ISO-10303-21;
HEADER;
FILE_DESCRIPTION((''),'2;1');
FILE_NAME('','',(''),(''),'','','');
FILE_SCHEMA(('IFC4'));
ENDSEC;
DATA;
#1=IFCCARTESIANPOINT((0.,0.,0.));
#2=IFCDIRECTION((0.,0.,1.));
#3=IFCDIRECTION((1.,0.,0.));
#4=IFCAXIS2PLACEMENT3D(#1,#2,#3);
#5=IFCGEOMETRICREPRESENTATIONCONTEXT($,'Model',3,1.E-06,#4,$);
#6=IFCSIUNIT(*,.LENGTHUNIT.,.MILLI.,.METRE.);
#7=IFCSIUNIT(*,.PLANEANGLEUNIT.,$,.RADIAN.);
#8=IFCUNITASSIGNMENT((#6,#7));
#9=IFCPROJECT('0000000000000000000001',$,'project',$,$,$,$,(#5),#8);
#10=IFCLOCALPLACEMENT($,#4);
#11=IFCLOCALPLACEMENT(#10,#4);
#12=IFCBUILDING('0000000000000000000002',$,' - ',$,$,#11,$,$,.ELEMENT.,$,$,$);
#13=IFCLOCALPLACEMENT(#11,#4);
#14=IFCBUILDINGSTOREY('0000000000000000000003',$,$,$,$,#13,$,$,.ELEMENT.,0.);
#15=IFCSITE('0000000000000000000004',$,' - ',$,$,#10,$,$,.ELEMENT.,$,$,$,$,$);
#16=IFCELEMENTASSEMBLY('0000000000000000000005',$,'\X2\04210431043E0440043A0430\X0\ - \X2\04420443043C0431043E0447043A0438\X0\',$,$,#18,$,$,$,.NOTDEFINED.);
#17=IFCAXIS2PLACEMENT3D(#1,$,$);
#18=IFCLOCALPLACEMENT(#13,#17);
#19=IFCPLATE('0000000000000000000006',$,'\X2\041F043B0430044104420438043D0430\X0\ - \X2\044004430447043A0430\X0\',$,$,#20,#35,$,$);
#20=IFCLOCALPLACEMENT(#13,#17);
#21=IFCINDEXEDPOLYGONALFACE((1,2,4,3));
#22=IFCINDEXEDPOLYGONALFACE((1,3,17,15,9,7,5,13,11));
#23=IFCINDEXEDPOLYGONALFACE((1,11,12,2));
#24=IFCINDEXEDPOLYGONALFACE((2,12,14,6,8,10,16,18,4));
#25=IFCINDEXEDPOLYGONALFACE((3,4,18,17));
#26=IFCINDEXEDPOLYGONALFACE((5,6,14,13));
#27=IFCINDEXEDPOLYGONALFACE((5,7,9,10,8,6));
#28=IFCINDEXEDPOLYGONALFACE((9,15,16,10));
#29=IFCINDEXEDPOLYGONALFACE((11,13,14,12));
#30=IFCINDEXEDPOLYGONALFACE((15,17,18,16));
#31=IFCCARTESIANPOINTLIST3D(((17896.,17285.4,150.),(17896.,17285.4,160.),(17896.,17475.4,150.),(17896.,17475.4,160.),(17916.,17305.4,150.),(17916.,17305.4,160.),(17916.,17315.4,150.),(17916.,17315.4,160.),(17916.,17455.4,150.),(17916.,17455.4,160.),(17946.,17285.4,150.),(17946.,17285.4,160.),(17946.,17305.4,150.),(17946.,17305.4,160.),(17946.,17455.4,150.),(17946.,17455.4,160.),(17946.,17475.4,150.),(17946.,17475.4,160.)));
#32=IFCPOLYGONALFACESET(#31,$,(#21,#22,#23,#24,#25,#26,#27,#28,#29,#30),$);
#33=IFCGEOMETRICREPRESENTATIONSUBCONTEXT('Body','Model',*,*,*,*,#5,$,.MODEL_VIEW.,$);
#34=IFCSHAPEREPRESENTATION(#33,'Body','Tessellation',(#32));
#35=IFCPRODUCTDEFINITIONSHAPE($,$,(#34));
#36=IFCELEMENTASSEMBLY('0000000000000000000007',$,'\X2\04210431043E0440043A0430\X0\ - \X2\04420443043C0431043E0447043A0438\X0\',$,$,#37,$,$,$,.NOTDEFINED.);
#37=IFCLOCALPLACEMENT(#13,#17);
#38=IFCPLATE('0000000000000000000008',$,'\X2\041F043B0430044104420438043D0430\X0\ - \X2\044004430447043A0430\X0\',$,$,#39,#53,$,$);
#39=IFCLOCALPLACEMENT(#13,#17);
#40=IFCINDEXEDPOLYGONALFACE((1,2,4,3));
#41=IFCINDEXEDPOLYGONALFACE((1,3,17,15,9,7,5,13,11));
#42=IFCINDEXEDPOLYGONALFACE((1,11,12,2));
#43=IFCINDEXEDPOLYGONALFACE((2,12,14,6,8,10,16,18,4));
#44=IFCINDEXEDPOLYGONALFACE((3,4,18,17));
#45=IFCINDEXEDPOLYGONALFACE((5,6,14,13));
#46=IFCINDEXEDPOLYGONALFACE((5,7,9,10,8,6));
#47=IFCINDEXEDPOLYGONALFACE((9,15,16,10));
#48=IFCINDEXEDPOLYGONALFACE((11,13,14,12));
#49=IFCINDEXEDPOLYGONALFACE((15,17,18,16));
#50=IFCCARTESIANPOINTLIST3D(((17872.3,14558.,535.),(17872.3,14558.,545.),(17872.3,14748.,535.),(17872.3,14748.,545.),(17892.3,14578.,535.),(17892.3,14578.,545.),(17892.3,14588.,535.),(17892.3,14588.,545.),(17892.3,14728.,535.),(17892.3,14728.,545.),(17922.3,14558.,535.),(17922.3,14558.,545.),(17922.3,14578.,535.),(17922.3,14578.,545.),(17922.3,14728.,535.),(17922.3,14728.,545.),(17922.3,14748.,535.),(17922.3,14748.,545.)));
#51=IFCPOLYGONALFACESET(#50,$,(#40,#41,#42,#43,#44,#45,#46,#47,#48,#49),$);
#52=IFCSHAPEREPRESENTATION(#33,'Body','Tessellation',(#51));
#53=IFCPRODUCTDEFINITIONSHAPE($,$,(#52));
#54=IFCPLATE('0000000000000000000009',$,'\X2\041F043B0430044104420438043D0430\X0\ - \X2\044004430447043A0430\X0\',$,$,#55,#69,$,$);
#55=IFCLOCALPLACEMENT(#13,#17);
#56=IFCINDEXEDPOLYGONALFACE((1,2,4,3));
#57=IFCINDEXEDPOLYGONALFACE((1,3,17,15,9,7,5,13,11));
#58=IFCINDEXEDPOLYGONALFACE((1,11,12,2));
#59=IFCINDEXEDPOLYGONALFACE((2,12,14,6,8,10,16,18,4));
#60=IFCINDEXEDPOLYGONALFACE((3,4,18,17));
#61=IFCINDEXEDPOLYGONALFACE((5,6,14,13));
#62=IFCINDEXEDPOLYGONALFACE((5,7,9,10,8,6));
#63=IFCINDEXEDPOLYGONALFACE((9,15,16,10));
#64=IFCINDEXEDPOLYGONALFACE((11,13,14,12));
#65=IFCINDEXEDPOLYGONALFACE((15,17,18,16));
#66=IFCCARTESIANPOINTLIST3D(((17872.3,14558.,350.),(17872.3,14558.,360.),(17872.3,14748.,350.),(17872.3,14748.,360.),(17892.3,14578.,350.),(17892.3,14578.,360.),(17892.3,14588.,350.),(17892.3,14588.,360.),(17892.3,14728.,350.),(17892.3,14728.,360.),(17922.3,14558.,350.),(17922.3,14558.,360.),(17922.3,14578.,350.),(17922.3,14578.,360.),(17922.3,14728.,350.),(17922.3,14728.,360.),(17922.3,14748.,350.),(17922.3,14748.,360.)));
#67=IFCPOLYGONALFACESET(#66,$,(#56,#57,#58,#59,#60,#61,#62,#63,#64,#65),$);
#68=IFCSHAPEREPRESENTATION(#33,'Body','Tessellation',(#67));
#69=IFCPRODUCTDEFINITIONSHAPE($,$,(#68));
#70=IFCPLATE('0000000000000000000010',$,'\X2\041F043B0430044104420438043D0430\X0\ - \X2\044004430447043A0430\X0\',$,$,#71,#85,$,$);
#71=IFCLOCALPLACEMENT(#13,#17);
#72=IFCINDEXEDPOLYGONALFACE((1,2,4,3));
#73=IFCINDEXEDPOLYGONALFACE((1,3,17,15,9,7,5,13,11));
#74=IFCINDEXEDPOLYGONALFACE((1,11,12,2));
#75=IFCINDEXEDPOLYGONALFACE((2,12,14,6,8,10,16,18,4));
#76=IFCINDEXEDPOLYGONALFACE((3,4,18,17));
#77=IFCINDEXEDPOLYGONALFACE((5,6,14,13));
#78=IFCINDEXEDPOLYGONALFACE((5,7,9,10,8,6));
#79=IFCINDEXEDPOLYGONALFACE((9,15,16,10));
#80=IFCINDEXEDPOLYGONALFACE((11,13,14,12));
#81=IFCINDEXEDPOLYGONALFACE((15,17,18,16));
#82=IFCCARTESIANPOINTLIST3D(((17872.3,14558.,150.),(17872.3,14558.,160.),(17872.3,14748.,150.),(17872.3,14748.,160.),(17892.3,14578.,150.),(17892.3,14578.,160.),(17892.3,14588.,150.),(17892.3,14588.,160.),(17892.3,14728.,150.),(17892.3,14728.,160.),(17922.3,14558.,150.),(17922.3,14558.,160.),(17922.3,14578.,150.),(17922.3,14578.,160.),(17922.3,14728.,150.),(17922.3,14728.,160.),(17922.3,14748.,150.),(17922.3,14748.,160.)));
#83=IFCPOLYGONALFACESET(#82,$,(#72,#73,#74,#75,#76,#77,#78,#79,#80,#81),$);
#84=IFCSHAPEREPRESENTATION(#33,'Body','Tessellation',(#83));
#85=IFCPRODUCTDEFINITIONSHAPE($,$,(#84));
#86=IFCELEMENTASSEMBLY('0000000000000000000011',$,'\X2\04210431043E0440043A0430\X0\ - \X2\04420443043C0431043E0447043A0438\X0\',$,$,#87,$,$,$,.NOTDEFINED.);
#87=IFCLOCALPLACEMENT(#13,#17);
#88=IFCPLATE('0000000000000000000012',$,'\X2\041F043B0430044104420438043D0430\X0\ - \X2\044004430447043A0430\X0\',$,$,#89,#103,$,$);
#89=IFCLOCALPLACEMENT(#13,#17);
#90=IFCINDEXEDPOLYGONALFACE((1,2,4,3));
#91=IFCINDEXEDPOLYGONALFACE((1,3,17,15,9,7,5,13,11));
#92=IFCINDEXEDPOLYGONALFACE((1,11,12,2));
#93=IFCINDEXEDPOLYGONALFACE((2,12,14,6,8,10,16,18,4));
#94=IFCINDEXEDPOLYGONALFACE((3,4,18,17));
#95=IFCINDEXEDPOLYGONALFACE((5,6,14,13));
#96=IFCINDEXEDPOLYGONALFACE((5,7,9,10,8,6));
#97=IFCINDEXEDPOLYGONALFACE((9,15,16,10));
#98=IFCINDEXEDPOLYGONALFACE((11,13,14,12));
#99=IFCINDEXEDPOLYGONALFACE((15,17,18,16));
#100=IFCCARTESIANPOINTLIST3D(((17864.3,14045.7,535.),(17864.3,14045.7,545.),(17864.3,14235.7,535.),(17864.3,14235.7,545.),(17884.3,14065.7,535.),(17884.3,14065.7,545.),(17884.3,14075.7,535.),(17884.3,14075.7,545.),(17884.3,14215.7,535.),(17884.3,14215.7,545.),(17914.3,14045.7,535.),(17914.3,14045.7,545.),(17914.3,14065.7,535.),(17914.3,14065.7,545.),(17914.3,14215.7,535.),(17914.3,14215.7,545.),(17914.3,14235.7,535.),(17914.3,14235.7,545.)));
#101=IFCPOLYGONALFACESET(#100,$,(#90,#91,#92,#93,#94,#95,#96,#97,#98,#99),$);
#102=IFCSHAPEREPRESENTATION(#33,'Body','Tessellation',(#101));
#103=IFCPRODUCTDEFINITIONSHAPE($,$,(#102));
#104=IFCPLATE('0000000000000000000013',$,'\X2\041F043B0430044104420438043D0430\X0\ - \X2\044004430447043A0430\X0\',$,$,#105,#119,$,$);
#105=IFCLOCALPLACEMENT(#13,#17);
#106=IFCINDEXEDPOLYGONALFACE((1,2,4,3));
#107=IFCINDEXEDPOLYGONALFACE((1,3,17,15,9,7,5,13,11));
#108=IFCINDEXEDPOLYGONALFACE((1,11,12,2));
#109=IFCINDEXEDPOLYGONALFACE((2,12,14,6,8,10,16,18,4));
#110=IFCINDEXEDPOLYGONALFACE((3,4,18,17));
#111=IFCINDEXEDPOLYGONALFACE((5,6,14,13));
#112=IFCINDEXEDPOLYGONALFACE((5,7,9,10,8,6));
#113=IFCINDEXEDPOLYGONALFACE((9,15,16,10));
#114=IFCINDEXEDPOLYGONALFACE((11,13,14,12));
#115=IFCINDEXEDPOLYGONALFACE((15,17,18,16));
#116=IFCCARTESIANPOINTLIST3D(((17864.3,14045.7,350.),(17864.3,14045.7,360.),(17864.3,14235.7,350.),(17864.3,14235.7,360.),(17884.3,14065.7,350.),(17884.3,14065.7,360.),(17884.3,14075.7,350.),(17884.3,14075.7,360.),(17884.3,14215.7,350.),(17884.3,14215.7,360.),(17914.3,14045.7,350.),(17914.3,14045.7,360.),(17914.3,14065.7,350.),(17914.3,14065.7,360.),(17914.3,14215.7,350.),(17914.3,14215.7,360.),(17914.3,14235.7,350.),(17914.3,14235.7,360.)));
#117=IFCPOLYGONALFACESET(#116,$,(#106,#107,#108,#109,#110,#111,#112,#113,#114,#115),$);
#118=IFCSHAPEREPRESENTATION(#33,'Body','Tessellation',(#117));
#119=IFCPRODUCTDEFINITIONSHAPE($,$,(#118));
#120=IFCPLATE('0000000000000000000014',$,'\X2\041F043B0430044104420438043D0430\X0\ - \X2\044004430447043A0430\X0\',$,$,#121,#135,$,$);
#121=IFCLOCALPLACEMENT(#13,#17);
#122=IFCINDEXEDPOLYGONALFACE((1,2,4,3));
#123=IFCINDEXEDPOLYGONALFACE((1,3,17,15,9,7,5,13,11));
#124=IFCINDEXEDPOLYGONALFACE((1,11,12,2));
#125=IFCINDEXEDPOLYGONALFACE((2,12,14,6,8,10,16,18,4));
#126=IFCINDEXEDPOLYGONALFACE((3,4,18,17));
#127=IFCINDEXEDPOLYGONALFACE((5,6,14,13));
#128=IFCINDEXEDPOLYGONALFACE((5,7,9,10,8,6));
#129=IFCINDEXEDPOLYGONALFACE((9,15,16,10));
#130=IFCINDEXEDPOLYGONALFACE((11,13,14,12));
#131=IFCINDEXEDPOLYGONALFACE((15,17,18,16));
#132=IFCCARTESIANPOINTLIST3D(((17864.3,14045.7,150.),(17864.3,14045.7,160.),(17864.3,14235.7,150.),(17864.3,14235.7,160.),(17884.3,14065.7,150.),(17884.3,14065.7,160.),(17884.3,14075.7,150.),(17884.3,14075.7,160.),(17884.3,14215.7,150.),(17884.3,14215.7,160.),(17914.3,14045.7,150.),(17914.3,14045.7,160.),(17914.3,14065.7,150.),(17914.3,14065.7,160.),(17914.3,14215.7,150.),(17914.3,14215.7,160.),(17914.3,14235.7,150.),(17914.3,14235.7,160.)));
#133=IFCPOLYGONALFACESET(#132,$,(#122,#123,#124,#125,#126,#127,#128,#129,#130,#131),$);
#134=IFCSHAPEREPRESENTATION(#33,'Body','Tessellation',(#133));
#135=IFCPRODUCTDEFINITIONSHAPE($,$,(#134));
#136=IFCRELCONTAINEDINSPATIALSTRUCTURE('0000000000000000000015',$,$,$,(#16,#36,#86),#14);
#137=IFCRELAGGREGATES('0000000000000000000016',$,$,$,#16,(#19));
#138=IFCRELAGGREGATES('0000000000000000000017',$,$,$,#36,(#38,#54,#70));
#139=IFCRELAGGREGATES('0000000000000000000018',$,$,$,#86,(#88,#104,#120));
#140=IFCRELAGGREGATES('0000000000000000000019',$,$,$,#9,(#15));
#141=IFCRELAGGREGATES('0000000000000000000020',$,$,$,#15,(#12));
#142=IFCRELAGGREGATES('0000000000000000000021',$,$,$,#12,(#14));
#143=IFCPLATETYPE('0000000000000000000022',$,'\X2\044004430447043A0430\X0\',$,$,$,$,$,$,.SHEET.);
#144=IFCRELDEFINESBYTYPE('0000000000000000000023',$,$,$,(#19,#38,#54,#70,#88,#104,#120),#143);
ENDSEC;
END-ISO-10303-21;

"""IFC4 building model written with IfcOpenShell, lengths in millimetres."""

from ifc_helpers import new_model, si_unit, frame, origin_with_axes, place, context, subcontext, project, spatial, line, indexed_curve, outline, extrude, source, transform, mapped, type_object, element, aggregate, save


model = new_model("IFC4")

# Units and contexts
model_context = context("Model", 3, precision=1e-06, world=origin_with_axes())
body_context = subcontext(model_context, "Body", "Model", "MODEL_VIEW")
ifc_project = project(units=[si_unit("LENGTHUNIT", "METRE", prefix="MILLI"), si_unit("PLANEANGLEUNIT", "RADIAN")], contexts=[model_context])

# Site, building, storey
site_placement = place(None, origin_with_axes())
site = spatial("IfcSite", under=ifc_project, at=site_placement, Name=" - ", CompositionType="ELEMENT")
building_placement = place(site_placement, origin_with_axes())
building = spatial("IfcBuilding", under=site, at=building_placement, Name=" - ", CompositionType="ELEMENT")
storey_placement = place(building_placement, origin_with_axes())
storey = spatial("IfcBuildingStorey", under=building, at=storey_placement, CompositionType="ELEMENT", Elevation=0.0)

# Shared definitions
plate_type = type_object("IfcPlateType", Name="ручка", PredefinedType="SHEET")
shared_shape = source(origin_with_axes(), body_context, "Body", "SweptSolid", [
    extrude(outline(indexed_curve([(-95.0, -25.0), (-75.0, -25.0), (-75.0, 5.0), (-65.0, 5.0), (75.0, 5.0), (75.0, -25.0), (95.0, -25.0), (95.0, 25.0), (-95.0, 25.0)], segments=[line(1, 2), line(2, 3), line(3, 4), line(4, 5), line(5, 6), line(6, 7), line(7, 8), line(8, 9), line(9, 1)])), origin_with_axes(), (0.0, 0.0, 1.0), 10.0),
])

# Element assemblies, plates
assembly_1_placement = place(storey_placement, frame((17946.0, 17580.4, 0.0), z_axis=(0.0, 0.0, 1.0), x_axis=(0.0, -1.0, 0.0)))
assembly_1 = element("IfcElementAssembly", 1, at=assembly_1_placement, inside=storey, Name="Сборка - тумбочки", PredefinedType="NOTDEFINED")
plate_1_placement = place(assembly_1_placement, frame((200.0, -25.0, 150.0), z_axis=(0.0, 0.0, 1.0), x_axis=(-1.0, 0.0, 0.0)))
plate_1 = element("IfcPlate", 2, at=plate_1_placement, type_object=plate_type, Name="Пластина - ручка", context=body_context, shape_type="MappedRepresentation", body=[
    mapped(shared_shape, transform((0.0, 0.0, 0.0), x_axis=(1.0, 0.0, 0.0), y_axis=(0.0, 1.0, 0.0), z_axis=(0.0, 0.0, 1.0), scale=1.0)),
])
aggregate(assembly_1, [plate_1])
assembly_2_placement = place(storey_placement, frame((17922.3, 14853.0, 0.0), z_axis=(0.0, 0.0, 1.0), x_axis=(0.0, -1.0, 0.0)))
assembly_2 = element("IfcElementAssembly", 3, at=assembly_2_placement, inside=storey, Name="Сборка - тумбочки", PredefinedType="NOTDEFINED")
plate_2_placement = place(assembly_2_placement, frame((200.0, -25.0, 535.0), z_axis=(0.0, 0.0, 1.0), x_axis=(-1.0, 0.0, 0.0)))
plate_2 = element("IfcPlate", 4, at=plate_2_placement, type_object=plate_type, Name="Пластина - ручка", context=body_context, shape_type="MappedRepresentation", body=[
    mapped(shared_shape, transform((0.0, 0.0, 0.0), x_axis=(1.0, 0.0, 0.0), y_axis=(0.0, 1.0, 0.0), z_axis=(0.0, 0.0, 1.0), scale=1.0)),
])
plate_3_placement = place(assembly_2_placement, frame((200.0, -25.0, 350.0), z_axis=(0.0, 0.0, 1.0), x_axis=(-1.0, 0.0, 0.0)))
plate_3 = element("IfcPlate", 5, at=plate_3_placement, type_object=plate_type, Name="Пластина - ручка", context=body_context, shape_type="MappedRepresentation", body=[
    mapped(shared_shape, transform((0.0, 0.0, 0.0), x_axis=(1.0, 0.0, 0.0), y_axis=(0.0, 1.0, 0.0), z_axis=(0.0, 0.0, 1.0), scale=1.0)),
])
plate_4_placement = place(assembly_2_placement, frame((200.0, -25.0, 150.0), z_axis=(0.0, 0.0, 1.0), x_axis=(-1.0, 0.0, 0.0)))
plate_4 = element("IfcPlate", 6, at=plate_4_placement, type_object=plate_type, Name="Пластина - ручка", context=body_context, shape_type="MappedRepresentation", body=[
    mapped(shared_shape, transform((0.0, 0.0, 0.0), x_axis=(1.0, 0.0, 0.0), y_axis=(0.0, 1.0, 0.0), z_axis=(0.0, 0.0, 1.0), scale=1.0)),
])
aggregate(assembly_2, [plate_2, plate_3, plate_4])
assembly_3_placement = place(storey_placement, frame((17914.3, 14340.7, 0.0), z_axis=(0.0, 0.0, 1.0), x_axis=(0.0, -1.0, 0.0)))
assembly_3 = element("IfcElementAssembly", 7, at=assembly_3_placement, inside=storey, Name="Сборка - тумбочки", PredefinedType="NOTDEFINED")
plate_5_placement = place(assembly_3_placement, frame((200.0, -25.0, 535.0), z_axis=(0.0, 0.0, 1.0), x_axis=(-1.0, 0.0, 0.0)))
plate_5 = element("IfcPlate", 8, at=plate_5_placement, type_object=plate_type, Name="Пластина - ручка", context=body_context, shape_type="MappedRepresentation", body=[
    mapped(shared_shape, transform((0.0, 0.0, 0.0), x_axis=(1.0, 0.0, 0.0), y_axis=(0.0, 1.0, 0.0), z_axis=(0.0, 0.0, 1.0), scale=1.0)),
])
plate_6_placement = place(assembly_3_placement, frame((200.0, -25.0, 350.0), z_axis=(0.0, 0.0, 1.0), x_axis=(-1.0, 0.0, 0.0)))
plate_6 = element("IfcPlate", 9, at=plate_6_placement, type_object=plate_type, Name="Пластина - ручка", context=body_context, shape_type="MappedRepresentation", body=[
    mapped(shared_shape, transform((0.0, 0.0, 0.0), x_axis=(1.0, 0.0, 0.0), y_axis=(0.0, 1.0, 0.0), z_axis=(0.0, 0.0, 1.0), scale=1.0)),
])
plate_7_placement = place(assembly_3_placement, frame((200.0, -25.0, 150.0), z_axis=(0.0, 0.0, 1.0), x_axis=(-1.0, 0.0, 0.0)))
plate_7 = element("IfcPlate", 10, at=plate_7_placement, type_object=plate_type, Name="Пластина - ручка", context=body_context, shape_type="MappedRepresentation", body=[
    mapped(shared_shape, transform((0.0, 0.0, 0.0), x_axis=(1.0, 0.0, 0.0), y_axis=(0.0, 1.0, 0.0), z_axis=(0.0, 0.0, 1.0), scale=1.0)),
])
aggregate(assembly_3, [plate_5, plate_6, plate_7])

save(model, "model.ifc")
